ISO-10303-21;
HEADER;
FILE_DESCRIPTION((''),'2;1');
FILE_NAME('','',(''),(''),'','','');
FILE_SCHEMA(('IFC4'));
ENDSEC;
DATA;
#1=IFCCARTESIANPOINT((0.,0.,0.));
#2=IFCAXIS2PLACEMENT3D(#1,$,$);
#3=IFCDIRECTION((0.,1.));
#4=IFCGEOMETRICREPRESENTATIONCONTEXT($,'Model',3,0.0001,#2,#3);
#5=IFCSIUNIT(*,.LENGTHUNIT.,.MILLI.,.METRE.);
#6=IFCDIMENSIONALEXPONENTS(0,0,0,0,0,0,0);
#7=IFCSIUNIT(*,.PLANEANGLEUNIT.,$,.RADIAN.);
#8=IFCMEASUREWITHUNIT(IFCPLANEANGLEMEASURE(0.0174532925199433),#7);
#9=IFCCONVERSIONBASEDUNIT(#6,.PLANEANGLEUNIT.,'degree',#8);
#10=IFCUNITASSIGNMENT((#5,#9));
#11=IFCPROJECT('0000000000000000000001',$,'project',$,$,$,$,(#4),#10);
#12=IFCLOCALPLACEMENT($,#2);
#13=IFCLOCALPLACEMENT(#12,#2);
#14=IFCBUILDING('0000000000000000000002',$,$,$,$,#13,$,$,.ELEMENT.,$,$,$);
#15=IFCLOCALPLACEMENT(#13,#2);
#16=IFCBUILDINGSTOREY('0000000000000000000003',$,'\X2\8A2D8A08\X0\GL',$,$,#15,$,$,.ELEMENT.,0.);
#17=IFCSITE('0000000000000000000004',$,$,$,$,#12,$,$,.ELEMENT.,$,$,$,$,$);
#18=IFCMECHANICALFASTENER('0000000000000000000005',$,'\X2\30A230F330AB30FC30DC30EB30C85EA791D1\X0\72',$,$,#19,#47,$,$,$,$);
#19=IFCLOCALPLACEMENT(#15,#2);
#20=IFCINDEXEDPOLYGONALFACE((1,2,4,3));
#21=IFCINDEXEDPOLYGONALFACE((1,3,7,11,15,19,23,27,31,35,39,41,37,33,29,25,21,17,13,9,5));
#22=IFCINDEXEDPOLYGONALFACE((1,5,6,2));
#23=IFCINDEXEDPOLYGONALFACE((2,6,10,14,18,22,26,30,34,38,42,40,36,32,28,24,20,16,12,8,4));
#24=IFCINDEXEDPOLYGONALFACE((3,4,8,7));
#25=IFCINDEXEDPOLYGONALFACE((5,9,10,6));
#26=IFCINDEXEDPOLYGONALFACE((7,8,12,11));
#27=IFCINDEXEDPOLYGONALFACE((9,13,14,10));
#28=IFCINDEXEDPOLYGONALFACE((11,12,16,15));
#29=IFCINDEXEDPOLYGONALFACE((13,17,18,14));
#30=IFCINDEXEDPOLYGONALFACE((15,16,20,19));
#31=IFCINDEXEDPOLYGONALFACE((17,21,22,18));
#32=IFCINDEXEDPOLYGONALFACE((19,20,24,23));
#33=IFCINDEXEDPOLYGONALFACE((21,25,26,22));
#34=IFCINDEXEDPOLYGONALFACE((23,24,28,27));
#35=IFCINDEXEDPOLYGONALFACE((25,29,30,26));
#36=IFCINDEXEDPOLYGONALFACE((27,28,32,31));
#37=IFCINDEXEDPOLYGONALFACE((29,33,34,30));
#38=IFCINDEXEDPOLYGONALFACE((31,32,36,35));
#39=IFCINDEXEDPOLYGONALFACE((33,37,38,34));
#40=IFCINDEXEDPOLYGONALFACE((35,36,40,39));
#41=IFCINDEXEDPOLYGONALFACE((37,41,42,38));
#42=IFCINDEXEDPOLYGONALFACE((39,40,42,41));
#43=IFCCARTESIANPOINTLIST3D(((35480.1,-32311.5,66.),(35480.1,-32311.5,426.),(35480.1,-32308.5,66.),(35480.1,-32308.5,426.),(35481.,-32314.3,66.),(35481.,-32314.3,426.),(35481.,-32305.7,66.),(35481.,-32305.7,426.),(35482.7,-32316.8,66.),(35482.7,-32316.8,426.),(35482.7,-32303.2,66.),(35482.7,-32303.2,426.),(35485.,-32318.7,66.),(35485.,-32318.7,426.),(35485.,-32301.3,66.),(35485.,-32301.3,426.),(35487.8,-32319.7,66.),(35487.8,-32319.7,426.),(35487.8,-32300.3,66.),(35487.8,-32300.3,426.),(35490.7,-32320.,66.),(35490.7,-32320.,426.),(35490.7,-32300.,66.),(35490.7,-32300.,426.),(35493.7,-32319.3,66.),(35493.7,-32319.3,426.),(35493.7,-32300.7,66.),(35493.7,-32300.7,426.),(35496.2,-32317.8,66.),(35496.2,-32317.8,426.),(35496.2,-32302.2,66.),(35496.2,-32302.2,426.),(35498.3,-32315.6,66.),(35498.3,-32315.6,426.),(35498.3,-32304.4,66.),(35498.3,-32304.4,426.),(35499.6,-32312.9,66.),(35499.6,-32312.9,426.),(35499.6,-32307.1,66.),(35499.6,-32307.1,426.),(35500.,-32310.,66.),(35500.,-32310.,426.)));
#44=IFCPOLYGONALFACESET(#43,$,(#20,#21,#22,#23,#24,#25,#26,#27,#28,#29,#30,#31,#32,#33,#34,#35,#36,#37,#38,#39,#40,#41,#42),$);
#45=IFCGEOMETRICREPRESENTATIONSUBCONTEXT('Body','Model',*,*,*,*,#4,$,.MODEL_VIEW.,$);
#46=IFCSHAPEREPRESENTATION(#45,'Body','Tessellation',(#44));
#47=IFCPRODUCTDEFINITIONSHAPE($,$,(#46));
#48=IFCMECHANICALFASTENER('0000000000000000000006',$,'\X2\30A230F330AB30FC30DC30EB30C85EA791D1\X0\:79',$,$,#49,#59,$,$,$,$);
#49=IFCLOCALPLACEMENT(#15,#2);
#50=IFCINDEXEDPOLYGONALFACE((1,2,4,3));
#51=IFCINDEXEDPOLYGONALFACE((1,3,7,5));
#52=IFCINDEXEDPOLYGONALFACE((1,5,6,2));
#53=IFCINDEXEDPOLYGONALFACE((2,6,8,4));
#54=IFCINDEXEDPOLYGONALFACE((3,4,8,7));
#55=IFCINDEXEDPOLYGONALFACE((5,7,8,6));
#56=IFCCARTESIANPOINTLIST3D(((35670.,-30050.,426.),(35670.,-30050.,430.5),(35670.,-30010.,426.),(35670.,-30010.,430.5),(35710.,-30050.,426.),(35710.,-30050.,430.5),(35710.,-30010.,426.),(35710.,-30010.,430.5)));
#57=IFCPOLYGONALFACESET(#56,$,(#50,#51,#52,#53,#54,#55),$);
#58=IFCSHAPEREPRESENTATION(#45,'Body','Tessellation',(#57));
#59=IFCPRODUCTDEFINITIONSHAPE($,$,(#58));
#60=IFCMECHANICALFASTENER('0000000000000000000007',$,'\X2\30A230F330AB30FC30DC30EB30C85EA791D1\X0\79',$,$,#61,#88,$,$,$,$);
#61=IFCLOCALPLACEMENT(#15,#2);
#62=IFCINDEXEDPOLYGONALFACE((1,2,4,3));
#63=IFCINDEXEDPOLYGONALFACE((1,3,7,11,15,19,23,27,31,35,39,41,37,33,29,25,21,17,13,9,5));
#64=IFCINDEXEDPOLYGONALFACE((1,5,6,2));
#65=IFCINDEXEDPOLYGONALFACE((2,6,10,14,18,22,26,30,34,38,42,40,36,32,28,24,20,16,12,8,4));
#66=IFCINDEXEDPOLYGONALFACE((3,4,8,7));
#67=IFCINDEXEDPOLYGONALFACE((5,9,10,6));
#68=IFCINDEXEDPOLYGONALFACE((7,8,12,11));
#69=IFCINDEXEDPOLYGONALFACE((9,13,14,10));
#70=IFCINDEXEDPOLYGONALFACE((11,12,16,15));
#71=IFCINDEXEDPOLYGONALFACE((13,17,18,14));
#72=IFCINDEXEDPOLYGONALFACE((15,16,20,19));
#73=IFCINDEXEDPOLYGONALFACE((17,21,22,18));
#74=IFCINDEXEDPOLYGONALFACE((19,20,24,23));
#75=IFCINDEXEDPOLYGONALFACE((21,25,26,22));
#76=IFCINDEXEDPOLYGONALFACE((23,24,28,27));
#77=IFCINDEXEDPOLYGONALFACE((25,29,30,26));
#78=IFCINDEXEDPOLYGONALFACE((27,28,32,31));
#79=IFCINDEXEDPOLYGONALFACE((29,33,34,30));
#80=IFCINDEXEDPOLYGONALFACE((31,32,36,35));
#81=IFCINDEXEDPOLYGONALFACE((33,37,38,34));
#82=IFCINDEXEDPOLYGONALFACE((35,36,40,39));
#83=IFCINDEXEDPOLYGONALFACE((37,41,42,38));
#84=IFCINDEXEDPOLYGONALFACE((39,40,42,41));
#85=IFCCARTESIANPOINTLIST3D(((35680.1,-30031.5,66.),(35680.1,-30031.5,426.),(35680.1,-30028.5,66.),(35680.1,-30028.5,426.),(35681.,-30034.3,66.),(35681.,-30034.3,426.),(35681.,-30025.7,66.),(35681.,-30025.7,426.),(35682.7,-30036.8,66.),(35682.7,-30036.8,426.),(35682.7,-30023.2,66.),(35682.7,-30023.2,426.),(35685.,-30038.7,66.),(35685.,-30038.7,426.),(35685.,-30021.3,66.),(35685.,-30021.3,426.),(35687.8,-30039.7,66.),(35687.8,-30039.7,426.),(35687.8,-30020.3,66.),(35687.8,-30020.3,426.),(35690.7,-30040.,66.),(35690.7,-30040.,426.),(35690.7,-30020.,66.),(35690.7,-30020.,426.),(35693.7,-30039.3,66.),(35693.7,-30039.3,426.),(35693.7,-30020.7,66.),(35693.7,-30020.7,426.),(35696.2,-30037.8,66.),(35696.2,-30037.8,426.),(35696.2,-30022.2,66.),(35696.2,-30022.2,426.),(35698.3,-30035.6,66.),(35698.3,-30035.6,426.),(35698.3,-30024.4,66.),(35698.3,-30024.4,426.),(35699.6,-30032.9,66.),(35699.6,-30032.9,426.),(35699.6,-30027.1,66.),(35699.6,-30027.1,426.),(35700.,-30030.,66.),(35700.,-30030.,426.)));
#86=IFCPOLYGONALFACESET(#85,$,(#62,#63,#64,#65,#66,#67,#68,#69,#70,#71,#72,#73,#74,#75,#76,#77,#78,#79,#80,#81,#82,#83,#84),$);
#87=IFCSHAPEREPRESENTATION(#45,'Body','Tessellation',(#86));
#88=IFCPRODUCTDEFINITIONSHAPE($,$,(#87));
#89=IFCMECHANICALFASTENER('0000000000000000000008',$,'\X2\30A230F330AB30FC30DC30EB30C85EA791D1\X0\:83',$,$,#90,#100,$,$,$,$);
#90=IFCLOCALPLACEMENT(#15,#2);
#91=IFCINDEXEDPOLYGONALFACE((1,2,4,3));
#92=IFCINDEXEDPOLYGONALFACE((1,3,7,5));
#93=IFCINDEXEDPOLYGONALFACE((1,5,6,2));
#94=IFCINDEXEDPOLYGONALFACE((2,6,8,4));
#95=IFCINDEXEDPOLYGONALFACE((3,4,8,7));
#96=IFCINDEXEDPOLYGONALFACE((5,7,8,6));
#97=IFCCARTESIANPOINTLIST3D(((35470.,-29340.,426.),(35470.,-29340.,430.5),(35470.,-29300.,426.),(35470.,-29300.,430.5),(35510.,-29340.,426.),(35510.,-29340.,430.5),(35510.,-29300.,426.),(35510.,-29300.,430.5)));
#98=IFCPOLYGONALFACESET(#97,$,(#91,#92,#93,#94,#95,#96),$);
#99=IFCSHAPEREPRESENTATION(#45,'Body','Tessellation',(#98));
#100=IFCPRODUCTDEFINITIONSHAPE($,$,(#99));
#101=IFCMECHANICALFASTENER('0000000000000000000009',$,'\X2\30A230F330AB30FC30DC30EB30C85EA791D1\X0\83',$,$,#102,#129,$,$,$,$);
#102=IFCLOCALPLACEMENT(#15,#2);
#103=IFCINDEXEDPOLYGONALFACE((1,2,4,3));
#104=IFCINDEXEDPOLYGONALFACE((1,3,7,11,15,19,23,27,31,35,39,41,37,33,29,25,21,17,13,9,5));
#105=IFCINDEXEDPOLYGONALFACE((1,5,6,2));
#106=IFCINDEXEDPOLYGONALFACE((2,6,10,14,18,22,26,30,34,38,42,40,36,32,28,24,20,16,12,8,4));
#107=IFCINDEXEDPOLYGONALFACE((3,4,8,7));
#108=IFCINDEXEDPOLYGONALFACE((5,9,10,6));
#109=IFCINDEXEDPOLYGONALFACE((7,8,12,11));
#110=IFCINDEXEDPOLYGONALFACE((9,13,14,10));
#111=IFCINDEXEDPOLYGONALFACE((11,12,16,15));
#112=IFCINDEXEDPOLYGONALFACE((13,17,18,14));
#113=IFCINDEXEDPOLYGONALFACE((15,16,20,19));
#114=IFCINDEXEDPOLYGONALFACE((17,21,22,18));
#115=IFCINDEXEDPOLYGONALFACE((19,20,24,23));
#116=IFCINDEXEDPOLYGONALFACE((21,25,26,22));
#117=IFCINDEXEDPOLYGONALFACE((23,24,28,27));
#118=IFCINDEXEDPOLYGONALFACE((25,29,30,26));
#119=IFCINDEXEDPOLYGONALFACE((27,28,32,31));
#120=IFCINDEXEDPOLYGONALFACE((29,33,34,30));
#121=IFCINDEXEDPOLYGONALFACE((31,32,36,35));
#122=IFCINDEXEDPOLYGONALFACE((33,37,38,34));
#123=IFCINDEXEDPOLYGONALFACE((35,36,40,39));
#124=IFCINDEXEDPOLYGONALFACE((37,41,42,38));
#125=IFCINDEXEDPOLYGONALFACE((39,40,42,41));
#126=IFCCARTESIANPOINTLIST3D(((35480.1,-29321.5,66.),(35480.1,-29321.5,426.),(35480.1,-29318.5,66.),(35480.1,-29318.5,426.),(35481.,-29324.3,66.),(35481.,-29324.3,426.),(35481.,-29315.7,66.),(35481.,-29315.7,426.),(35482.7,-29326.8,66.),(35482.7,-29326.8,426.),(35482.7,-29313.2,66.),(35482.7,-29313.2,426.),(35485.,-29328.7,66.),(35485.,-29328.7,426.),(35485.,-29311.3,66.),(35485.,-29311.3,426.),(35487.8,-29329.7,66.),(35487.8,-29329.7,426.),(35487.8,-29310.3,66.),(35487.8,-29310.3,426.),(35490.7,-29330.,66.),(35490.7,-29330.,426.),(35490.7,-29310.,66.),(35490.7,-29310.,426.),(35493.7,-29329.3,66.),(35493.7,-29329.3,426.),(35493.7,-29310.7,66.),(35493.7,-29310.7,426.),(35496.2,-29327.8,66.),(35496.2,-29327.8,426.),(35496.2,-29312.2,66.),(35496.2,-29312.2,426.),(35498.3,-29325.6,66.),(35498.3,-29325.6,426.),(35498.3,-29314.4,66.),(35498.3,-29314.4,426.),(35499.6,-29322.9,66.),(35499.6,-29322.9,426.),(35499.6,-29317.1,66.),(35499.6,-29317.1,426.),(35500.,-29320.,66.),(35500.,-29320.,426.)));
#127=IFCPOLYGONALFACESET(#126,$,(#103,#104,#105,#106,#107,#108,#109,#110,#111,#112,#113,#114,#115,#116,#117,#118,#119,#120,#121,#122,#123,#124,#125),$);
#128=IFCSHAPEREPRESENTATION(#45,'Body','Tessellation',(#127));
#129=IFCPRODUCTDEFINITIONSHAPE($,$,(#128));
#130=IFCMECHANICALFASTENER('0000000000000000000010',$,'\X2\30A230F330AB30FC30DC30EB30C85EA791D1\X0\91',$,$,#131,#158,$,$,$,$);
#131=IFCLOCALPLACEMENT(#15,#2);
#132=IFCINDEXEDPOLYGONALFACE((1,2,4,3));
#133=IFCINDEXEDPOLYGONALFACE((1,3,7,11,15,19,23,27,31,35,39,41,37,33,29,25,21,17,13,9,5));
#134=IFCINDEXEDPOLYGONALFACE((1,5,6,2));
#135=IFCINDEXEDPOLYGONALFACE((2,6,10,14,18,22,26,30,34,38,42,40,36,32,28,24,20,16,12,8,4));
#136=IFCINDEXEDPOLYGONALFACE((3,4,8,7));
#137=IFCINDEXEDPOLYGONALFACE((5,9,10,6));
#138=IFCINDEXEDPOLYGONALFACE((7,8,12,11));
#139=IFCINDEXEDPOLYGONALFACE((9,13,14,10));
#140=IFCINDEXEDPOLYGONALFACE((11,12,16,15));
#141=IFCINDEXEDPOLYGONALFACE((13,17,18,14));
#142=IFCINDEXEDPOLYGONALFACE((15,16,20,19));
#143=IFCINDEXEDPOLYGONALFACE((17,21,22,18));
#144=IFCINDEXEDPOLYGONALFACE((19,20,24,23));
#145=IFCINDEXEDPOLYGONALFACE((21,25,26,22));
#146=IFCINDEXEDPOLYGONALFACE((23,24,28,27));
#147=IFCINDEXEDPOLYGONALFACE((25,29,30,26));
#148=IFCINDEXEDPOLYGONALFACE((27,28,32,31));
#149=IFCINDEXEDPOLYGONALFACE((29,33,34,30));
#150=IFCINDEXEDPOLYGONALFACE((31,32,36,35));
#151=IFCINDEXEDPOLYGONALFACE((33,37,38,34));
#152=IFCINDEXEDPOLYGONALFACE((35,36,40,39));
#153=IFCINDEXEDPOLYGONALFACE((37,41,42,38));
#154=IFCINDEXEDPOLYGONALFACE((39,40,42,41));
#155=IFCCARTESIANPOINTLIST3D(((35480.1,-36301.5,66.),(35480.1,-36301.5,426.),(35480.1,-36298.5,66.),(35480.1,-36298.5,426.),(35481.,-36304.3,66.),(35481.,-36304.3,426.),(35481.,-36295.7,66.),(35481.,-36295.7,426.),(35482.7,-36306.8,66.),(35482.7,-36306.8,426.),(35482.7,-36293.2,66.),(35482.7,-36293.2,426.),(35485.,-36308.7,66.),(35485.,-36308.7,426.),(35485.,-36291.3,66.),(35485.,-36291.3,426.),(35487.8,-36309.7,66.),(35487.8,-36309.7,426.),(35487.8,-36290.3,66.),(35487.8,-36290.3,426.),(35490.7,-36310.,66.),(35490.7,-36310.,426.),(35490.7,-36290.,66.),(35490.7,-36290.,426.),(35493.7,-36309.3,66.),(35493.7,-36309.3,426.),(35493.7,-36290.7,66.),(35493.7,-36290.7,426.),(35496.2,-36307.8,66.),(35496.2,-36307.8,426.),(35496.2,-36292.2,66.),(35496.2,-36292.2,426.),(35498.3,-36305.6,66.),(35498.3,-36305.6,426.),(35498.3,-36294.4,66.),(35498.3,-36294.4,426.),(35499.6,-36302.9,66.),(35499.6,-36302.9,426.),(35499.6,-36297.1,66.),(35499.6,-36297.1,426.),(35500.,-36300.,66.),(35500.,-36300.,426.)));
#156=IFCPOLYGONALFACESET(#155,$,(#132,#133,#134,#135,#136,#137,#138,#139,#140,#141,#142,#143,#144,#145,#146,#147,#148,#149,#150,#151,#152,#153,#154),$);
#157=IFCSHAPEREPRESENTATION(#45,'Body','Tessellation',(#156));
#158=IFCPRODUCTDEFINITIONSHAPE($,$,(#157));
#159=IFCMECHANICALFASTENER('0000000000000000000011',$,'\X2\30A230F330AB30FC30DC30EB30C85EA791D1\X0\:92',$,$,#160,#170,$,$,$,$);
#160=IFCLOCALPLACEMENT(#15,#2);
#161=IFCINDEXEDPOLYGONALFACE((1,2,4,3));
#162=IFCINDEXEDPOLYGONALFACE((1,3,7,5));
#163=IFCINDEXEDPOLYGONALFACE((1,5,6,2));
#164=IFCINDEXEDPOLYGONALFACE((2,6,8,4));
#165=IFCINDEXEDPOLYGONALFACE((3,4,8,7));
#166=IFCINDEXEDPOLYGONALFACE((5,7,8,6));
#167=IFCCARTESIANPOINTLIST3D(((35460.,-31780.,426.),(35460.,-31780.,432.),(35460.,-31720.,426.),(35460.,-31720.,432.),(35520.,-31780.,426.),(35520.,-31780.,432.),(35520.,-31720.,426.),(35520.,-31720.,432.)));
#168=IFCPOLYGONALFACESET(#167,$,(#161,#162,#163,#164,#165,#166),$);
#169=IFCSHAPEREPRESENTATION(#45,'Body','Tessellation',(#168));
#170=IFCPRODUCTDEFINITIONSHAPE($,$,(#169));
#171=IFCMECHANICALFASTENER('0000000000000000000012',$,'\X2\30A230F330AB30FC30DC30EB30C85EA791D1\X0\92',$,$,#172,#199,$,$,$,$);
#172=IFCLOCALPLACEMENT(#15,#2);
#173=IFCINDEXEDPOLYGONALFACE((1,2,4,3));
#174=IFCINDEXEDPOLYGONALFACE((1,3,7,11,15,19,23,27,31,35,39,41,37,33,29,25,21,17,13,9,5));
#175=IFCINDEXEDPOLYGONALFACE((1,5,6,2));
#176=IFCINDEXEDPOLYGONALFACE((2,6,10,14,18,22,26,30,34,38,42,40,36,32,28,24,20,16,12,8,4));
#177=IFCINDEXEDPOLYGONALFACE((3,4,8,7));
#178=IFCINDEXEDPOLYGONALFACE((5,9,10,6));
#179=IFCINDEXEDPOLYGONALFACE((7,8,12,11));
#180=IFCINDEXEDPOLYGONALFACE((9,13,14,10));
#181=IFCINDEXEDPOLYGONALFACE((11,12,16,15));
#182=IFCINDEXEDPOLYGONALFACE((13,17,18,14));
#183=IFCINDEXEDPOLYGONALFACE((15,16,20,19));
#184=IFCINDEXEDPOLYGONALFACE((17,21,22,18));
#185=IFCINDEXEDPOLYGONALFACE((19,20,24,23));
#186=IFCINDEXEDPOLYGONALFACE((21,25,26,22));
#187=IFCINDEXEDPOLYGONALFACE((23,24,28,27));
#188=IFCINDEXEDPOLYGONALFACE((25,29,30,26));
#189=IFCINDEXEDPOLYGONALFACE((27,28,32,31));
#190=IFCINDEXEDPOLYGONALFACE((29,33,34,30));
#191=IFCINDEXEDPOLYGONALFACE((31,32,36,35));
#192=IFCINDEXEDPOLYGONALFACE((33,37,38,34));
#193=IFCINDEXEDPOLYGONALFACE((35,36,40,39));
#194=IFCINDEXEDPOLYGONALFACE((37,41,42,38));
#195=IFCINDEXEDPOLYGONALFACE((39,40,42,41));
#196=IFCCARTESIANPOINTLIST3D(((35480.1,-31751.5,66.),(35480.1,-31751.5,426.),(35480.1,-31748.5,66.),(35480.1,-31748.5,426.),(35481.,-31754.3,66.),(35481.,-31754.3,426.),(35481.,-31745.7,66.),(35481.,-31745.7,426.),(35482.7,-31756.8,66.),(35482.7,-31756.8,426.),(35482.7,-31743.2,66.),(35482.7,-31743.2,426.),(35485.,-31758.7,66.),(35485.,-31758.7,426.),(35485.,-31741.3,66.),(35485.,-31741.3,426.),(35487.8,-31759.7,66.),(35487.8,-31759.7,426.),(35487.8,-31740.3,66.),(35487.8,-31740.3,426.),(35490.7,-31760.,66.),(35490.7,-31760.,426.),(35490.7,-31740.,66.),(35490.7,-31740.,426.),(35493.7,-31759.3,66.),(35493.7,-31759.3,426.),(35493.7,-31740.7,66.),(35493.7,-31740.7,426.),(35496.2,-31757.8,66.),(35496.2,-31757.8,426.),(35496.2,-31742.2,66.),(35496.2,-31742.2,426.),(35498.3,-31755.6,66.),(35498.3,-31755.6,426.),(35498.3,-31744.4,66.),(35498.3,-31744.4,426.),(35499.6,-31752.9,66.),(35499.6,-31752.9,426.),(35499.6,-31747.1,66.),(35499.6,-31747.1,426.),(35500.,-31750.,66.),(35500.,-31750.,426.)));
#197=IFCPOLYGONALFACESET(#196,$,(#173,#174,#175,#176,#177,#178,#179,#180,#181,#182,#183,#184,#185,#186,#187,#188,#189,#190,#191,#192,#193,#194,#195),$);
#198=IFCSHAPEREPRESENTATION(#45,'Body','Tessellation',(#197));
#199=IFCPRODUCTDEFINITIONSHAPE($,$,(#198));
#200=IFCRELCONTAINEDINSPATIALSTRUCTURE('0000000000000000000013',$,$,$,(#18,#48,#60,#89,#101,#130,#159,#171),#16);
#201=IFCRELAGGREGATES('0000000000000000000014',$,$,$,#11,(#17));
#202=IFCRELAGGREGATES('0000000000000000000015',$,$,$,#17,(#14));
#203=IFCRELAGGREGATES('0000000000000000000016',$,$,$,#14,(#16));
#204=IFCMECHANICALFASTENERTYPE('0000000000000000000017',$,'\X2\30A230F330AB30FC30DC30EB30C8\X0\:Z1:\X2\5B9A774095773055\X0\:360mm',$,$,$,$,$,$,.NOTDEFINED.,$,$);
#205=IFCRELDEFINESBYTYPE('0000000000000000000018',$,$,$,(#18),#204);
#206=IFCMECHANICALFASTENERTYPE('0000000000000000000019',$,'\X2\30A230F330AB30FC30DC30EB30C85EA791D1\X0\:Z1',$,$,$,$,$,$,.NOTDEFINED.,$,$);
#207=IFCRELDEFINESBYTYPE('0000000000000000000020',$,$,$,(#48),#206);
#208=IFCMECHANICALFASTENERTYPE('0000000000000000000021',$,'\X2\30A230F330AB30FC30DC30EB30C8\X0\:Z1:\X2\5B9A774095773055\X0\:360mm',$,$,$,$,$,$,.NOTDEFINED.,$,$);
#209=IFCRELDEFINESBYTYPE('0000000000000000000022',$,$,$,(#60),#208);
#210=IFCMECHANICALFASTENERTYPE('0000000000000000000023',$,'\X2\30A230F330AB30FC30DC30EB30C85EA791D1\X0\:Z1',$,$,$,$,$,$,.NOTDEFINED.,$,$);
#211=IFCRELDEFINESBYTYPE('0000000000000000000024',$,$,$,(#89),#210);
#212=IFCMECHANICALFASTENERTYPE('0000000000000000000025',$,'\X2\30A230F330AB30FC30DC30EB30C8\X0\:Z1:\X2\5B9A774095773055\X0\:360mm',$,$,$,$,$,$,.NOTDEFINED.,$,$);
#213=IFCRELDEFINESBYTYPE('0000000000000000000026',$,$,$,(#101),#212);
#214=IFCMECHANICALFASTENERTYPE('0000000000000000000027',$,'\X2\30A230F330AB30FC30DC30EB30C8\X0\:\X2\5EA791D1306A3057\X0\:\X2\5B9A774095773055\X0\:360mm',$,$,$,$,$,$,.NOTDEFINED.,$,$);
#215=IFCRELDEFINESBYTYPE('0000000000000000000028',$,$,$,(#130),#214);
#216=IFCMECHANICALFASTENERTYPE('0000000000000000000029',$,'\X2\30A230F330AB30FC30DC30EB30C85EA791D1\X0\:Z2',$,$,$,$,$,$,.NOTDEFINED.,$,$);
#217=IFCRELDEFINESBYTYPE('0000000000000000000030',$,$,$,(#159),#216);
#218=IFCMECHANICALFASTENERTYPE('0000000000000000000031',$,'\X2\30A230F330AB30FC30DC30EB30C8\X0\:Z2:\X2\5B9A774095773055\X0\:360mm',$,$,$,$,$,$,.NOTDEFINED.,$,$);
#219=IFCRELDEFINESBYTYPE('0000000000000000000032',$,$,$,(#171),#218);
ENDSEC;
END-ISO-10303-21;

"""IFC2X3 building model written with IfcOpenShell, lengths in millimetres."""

from ifc_helpers import new_model, entity, si_unit, converted_unit, direction, frame, origin, origin_with_axes, origin_2d, place, context, subcontext, project, spatial, rectangle, circle, extrude, type_object, element, save


model = new_model("IFC2X3")

# Units and contexts
model_context = context("Model", 3, precision=0.0001, world=origin(), true_north=direction((0.0, 1.0)))
body_context = subcontext(model_context, "Body", "Model", "MODEL_VIEW")
ifc_project = project(units=[si_unit("LENGTHUNIT", "METRE", prefix="MILLI"), converted_unit("PLANEANGLEUNIT", "degree", entity("IfcPlaneAngleMeasure", 0.0174532925199433), si_unit("PLANEANGLEUNIT", "RADIAN"), dimensions=[0, 0, 0, 0, 0, 0, 0])], contexts=[model_context])

# Site, building, storey
site_placement = place(None, origin())
site = spatial("IfcSite", under=ifc_project, at=site_placement, CompositionType="ELEMENT")
building_placement = place(site_placement, origin())
building = spatial("IfcBuilding", under=site, at=building_placement, CompositionType="ELEMENT")
storey_placement = place(building_placement, origin())
storey = spatial("IfcBuildingStorey", under=building, at=storey_placement, Name="設計GL", CompositionType="ELEMENT", Elevation=0.0)

# Mechanical fasteners
mechanical_fastener_type_1 = type_object("IfcMechanicalFastenerType", Name="アンカーボルト:Z1:定着長さ:360mm")
mechanical_fastener_1_placement = place(storey_placement, frame((35490.0, -32310.0, 66.0)))
element("IfcMechanicalFastener", 1, at=mechanical_fastener_1_placement, inside=storey, type_object=mechanical_fastener_type_1, Name="アンカーボルト座金72", context=body_context, shape_type="SweptSolid", body=[
    extrude(circle(Radius=10.0, at=origin_2d()), origin_with_axes(), (0.0, 0.0, 1.0), 360.0),
])
mechanical_fastener_type_2 = type_object("IfcMechanicalFastenerType", Name="アンカーボルト座金:Z1")
mechanical_fastener_2_placement = place(storey_placement, frame((35690.0, -30030.0, 426.0)))
element("IfcMechanicalFastener", 2, at=mechanical_fastener_2_placement, inside=storey, type_object=mechanical_fastener_type_2, Name="アンカーボルト座金:79", context=body_context, shape_type="SweptSolid", body=[
    extrude(rectangle(XDim=40.0, YDim=40.0, at=origin_2d()), origin_with_axes(), (0.0, 0.0, 1.0), 4.5),
])
mechanical_fastener_type_3 = type_object("IfcMechanicalFastenerType", Name="アンカーボルト:Z1:定着長さ:360mm")
mechanical_fastener_3_placement = place(storey_placement, frame((35690.0, -30030.0, 66.0)))
element("IfcMechanicalFastener", 3, at=mechanical_fastener_3_placement, inside=storey, type_object=mechanical_fastener_type_3, Name="アンカーボルト座金79", context=body_context, shape_type="SweptSolid", body=[
    extrude(circle(Radius=10.0, at=origin_2d()), origin_with_axes(), (0.0, 0.0, 1.0), 360.0),
])
mechanical_fastener_type_4 = type_object("IfcMechanicalFastenerType", Name="アンカーボルト座金:Z1")
mechanical_fastener_4_placement = place(storey_placement, frame((35490.0, -29320.0, 426.0)))
element("IfcMechanicalFastener", 4, at=mechanical_fastener_4_placement, inside=storey, type_object=mechanical_fastener_type_4, Name="アンカーボルト座金:83", context=body_context, shape_type="SweptSolid", body=[
    extrude(rectangle(XDim=40.0, YDim=40.0, at=origin_2d()), origin_with_axes(), (0.0, 0.0, 1.0), 4.5),
])
mechanical_fastener_type_5 = type_object("IfcMechanicalFastenerType", Name="アンカーボルト:Z1:定着長さ:360mm")
mechanical_fastener_5_placement = place(storey_placement, frame((35490.0, -29320.0, 66.0)))
element("IfcMechanicalFastener", 5, at=mechanical_fastener_5_placement, inside=storey, type_object=mechanical_fastener_type_5, Name="アンカーボルト座金83", context=body_context, shape_type="SweptSolid", body=[
    extrude(circle(Radius=10.0, at=origin_2d()), origin_with_axes(), (0.0, 0.0, 1.0), 360.0),
])
mechanical_fastener_type_6 = type_object("IfcMechanicalFastenerType", Name="アンカーボルト:座金なし:定着長さ:360mm")
mechanical_fastener_6_placement = place(storey_placement, frame((35490.0, -36300.0, 66.0)))
element("IfcMechanicalFastener", 6, at=mechanical_fastener_6_placement, inside=storey, type_object=mechanical_fastener_type_6, Name="アンカーボルト座金91", context=body_context, shape_type="SweptSolid", body=[
    extrude(circle(Radius=10.0, at=origin_2d()), origin_with_axes(), (0.0, 0.0, 1.0), 360.0),
])
mechanical_fastener_type_7 = type_object("IfcMechanicalFastenerType", Name="アンカーボルト座金:Z2")
mechanical_fastener_7_placement = place(storey_placement, frame((35490.0, -31750.0, 426.0)))
element("IfcMechanicalFastener", 7, at=mechanical_fastener_7_placement, inside=storey, type_object=mechanical_fastener_type_7, Name="アンカーボルト座金:92", context=body_context, shape_type="SweptSolid", body=[
    extrude(rectangle(XDim=60.0, YDim=60.0, at=origin_2d()), origin_with_axes(), (0.0, 0.0, 1.0), 6.0),
])
mechanical_fastener_type_8 = type_object("IfcMechanicalFastenerType", Name="アンカーボルト:Z2:定着長さ:360mm")
mechanical_fastener_8_placement = place(storey_placement, frame((35490.0, -31750.0, 66.0)))
element("IfcMechanicalFastener", 8, at=mechanical_fastener_8_placement, inside=storey, type_object=mechanical_fastener_type_8, Name="アンカーボルト座金92", context=body_context, shape_type="SweptSolid", body=[
    extrude(circle(Radius=10.0, at=origin_2d()), origin_with_axes(), (0.0, 0.0, 1.0), 360.0),
])

save(model, "model.ifc")
